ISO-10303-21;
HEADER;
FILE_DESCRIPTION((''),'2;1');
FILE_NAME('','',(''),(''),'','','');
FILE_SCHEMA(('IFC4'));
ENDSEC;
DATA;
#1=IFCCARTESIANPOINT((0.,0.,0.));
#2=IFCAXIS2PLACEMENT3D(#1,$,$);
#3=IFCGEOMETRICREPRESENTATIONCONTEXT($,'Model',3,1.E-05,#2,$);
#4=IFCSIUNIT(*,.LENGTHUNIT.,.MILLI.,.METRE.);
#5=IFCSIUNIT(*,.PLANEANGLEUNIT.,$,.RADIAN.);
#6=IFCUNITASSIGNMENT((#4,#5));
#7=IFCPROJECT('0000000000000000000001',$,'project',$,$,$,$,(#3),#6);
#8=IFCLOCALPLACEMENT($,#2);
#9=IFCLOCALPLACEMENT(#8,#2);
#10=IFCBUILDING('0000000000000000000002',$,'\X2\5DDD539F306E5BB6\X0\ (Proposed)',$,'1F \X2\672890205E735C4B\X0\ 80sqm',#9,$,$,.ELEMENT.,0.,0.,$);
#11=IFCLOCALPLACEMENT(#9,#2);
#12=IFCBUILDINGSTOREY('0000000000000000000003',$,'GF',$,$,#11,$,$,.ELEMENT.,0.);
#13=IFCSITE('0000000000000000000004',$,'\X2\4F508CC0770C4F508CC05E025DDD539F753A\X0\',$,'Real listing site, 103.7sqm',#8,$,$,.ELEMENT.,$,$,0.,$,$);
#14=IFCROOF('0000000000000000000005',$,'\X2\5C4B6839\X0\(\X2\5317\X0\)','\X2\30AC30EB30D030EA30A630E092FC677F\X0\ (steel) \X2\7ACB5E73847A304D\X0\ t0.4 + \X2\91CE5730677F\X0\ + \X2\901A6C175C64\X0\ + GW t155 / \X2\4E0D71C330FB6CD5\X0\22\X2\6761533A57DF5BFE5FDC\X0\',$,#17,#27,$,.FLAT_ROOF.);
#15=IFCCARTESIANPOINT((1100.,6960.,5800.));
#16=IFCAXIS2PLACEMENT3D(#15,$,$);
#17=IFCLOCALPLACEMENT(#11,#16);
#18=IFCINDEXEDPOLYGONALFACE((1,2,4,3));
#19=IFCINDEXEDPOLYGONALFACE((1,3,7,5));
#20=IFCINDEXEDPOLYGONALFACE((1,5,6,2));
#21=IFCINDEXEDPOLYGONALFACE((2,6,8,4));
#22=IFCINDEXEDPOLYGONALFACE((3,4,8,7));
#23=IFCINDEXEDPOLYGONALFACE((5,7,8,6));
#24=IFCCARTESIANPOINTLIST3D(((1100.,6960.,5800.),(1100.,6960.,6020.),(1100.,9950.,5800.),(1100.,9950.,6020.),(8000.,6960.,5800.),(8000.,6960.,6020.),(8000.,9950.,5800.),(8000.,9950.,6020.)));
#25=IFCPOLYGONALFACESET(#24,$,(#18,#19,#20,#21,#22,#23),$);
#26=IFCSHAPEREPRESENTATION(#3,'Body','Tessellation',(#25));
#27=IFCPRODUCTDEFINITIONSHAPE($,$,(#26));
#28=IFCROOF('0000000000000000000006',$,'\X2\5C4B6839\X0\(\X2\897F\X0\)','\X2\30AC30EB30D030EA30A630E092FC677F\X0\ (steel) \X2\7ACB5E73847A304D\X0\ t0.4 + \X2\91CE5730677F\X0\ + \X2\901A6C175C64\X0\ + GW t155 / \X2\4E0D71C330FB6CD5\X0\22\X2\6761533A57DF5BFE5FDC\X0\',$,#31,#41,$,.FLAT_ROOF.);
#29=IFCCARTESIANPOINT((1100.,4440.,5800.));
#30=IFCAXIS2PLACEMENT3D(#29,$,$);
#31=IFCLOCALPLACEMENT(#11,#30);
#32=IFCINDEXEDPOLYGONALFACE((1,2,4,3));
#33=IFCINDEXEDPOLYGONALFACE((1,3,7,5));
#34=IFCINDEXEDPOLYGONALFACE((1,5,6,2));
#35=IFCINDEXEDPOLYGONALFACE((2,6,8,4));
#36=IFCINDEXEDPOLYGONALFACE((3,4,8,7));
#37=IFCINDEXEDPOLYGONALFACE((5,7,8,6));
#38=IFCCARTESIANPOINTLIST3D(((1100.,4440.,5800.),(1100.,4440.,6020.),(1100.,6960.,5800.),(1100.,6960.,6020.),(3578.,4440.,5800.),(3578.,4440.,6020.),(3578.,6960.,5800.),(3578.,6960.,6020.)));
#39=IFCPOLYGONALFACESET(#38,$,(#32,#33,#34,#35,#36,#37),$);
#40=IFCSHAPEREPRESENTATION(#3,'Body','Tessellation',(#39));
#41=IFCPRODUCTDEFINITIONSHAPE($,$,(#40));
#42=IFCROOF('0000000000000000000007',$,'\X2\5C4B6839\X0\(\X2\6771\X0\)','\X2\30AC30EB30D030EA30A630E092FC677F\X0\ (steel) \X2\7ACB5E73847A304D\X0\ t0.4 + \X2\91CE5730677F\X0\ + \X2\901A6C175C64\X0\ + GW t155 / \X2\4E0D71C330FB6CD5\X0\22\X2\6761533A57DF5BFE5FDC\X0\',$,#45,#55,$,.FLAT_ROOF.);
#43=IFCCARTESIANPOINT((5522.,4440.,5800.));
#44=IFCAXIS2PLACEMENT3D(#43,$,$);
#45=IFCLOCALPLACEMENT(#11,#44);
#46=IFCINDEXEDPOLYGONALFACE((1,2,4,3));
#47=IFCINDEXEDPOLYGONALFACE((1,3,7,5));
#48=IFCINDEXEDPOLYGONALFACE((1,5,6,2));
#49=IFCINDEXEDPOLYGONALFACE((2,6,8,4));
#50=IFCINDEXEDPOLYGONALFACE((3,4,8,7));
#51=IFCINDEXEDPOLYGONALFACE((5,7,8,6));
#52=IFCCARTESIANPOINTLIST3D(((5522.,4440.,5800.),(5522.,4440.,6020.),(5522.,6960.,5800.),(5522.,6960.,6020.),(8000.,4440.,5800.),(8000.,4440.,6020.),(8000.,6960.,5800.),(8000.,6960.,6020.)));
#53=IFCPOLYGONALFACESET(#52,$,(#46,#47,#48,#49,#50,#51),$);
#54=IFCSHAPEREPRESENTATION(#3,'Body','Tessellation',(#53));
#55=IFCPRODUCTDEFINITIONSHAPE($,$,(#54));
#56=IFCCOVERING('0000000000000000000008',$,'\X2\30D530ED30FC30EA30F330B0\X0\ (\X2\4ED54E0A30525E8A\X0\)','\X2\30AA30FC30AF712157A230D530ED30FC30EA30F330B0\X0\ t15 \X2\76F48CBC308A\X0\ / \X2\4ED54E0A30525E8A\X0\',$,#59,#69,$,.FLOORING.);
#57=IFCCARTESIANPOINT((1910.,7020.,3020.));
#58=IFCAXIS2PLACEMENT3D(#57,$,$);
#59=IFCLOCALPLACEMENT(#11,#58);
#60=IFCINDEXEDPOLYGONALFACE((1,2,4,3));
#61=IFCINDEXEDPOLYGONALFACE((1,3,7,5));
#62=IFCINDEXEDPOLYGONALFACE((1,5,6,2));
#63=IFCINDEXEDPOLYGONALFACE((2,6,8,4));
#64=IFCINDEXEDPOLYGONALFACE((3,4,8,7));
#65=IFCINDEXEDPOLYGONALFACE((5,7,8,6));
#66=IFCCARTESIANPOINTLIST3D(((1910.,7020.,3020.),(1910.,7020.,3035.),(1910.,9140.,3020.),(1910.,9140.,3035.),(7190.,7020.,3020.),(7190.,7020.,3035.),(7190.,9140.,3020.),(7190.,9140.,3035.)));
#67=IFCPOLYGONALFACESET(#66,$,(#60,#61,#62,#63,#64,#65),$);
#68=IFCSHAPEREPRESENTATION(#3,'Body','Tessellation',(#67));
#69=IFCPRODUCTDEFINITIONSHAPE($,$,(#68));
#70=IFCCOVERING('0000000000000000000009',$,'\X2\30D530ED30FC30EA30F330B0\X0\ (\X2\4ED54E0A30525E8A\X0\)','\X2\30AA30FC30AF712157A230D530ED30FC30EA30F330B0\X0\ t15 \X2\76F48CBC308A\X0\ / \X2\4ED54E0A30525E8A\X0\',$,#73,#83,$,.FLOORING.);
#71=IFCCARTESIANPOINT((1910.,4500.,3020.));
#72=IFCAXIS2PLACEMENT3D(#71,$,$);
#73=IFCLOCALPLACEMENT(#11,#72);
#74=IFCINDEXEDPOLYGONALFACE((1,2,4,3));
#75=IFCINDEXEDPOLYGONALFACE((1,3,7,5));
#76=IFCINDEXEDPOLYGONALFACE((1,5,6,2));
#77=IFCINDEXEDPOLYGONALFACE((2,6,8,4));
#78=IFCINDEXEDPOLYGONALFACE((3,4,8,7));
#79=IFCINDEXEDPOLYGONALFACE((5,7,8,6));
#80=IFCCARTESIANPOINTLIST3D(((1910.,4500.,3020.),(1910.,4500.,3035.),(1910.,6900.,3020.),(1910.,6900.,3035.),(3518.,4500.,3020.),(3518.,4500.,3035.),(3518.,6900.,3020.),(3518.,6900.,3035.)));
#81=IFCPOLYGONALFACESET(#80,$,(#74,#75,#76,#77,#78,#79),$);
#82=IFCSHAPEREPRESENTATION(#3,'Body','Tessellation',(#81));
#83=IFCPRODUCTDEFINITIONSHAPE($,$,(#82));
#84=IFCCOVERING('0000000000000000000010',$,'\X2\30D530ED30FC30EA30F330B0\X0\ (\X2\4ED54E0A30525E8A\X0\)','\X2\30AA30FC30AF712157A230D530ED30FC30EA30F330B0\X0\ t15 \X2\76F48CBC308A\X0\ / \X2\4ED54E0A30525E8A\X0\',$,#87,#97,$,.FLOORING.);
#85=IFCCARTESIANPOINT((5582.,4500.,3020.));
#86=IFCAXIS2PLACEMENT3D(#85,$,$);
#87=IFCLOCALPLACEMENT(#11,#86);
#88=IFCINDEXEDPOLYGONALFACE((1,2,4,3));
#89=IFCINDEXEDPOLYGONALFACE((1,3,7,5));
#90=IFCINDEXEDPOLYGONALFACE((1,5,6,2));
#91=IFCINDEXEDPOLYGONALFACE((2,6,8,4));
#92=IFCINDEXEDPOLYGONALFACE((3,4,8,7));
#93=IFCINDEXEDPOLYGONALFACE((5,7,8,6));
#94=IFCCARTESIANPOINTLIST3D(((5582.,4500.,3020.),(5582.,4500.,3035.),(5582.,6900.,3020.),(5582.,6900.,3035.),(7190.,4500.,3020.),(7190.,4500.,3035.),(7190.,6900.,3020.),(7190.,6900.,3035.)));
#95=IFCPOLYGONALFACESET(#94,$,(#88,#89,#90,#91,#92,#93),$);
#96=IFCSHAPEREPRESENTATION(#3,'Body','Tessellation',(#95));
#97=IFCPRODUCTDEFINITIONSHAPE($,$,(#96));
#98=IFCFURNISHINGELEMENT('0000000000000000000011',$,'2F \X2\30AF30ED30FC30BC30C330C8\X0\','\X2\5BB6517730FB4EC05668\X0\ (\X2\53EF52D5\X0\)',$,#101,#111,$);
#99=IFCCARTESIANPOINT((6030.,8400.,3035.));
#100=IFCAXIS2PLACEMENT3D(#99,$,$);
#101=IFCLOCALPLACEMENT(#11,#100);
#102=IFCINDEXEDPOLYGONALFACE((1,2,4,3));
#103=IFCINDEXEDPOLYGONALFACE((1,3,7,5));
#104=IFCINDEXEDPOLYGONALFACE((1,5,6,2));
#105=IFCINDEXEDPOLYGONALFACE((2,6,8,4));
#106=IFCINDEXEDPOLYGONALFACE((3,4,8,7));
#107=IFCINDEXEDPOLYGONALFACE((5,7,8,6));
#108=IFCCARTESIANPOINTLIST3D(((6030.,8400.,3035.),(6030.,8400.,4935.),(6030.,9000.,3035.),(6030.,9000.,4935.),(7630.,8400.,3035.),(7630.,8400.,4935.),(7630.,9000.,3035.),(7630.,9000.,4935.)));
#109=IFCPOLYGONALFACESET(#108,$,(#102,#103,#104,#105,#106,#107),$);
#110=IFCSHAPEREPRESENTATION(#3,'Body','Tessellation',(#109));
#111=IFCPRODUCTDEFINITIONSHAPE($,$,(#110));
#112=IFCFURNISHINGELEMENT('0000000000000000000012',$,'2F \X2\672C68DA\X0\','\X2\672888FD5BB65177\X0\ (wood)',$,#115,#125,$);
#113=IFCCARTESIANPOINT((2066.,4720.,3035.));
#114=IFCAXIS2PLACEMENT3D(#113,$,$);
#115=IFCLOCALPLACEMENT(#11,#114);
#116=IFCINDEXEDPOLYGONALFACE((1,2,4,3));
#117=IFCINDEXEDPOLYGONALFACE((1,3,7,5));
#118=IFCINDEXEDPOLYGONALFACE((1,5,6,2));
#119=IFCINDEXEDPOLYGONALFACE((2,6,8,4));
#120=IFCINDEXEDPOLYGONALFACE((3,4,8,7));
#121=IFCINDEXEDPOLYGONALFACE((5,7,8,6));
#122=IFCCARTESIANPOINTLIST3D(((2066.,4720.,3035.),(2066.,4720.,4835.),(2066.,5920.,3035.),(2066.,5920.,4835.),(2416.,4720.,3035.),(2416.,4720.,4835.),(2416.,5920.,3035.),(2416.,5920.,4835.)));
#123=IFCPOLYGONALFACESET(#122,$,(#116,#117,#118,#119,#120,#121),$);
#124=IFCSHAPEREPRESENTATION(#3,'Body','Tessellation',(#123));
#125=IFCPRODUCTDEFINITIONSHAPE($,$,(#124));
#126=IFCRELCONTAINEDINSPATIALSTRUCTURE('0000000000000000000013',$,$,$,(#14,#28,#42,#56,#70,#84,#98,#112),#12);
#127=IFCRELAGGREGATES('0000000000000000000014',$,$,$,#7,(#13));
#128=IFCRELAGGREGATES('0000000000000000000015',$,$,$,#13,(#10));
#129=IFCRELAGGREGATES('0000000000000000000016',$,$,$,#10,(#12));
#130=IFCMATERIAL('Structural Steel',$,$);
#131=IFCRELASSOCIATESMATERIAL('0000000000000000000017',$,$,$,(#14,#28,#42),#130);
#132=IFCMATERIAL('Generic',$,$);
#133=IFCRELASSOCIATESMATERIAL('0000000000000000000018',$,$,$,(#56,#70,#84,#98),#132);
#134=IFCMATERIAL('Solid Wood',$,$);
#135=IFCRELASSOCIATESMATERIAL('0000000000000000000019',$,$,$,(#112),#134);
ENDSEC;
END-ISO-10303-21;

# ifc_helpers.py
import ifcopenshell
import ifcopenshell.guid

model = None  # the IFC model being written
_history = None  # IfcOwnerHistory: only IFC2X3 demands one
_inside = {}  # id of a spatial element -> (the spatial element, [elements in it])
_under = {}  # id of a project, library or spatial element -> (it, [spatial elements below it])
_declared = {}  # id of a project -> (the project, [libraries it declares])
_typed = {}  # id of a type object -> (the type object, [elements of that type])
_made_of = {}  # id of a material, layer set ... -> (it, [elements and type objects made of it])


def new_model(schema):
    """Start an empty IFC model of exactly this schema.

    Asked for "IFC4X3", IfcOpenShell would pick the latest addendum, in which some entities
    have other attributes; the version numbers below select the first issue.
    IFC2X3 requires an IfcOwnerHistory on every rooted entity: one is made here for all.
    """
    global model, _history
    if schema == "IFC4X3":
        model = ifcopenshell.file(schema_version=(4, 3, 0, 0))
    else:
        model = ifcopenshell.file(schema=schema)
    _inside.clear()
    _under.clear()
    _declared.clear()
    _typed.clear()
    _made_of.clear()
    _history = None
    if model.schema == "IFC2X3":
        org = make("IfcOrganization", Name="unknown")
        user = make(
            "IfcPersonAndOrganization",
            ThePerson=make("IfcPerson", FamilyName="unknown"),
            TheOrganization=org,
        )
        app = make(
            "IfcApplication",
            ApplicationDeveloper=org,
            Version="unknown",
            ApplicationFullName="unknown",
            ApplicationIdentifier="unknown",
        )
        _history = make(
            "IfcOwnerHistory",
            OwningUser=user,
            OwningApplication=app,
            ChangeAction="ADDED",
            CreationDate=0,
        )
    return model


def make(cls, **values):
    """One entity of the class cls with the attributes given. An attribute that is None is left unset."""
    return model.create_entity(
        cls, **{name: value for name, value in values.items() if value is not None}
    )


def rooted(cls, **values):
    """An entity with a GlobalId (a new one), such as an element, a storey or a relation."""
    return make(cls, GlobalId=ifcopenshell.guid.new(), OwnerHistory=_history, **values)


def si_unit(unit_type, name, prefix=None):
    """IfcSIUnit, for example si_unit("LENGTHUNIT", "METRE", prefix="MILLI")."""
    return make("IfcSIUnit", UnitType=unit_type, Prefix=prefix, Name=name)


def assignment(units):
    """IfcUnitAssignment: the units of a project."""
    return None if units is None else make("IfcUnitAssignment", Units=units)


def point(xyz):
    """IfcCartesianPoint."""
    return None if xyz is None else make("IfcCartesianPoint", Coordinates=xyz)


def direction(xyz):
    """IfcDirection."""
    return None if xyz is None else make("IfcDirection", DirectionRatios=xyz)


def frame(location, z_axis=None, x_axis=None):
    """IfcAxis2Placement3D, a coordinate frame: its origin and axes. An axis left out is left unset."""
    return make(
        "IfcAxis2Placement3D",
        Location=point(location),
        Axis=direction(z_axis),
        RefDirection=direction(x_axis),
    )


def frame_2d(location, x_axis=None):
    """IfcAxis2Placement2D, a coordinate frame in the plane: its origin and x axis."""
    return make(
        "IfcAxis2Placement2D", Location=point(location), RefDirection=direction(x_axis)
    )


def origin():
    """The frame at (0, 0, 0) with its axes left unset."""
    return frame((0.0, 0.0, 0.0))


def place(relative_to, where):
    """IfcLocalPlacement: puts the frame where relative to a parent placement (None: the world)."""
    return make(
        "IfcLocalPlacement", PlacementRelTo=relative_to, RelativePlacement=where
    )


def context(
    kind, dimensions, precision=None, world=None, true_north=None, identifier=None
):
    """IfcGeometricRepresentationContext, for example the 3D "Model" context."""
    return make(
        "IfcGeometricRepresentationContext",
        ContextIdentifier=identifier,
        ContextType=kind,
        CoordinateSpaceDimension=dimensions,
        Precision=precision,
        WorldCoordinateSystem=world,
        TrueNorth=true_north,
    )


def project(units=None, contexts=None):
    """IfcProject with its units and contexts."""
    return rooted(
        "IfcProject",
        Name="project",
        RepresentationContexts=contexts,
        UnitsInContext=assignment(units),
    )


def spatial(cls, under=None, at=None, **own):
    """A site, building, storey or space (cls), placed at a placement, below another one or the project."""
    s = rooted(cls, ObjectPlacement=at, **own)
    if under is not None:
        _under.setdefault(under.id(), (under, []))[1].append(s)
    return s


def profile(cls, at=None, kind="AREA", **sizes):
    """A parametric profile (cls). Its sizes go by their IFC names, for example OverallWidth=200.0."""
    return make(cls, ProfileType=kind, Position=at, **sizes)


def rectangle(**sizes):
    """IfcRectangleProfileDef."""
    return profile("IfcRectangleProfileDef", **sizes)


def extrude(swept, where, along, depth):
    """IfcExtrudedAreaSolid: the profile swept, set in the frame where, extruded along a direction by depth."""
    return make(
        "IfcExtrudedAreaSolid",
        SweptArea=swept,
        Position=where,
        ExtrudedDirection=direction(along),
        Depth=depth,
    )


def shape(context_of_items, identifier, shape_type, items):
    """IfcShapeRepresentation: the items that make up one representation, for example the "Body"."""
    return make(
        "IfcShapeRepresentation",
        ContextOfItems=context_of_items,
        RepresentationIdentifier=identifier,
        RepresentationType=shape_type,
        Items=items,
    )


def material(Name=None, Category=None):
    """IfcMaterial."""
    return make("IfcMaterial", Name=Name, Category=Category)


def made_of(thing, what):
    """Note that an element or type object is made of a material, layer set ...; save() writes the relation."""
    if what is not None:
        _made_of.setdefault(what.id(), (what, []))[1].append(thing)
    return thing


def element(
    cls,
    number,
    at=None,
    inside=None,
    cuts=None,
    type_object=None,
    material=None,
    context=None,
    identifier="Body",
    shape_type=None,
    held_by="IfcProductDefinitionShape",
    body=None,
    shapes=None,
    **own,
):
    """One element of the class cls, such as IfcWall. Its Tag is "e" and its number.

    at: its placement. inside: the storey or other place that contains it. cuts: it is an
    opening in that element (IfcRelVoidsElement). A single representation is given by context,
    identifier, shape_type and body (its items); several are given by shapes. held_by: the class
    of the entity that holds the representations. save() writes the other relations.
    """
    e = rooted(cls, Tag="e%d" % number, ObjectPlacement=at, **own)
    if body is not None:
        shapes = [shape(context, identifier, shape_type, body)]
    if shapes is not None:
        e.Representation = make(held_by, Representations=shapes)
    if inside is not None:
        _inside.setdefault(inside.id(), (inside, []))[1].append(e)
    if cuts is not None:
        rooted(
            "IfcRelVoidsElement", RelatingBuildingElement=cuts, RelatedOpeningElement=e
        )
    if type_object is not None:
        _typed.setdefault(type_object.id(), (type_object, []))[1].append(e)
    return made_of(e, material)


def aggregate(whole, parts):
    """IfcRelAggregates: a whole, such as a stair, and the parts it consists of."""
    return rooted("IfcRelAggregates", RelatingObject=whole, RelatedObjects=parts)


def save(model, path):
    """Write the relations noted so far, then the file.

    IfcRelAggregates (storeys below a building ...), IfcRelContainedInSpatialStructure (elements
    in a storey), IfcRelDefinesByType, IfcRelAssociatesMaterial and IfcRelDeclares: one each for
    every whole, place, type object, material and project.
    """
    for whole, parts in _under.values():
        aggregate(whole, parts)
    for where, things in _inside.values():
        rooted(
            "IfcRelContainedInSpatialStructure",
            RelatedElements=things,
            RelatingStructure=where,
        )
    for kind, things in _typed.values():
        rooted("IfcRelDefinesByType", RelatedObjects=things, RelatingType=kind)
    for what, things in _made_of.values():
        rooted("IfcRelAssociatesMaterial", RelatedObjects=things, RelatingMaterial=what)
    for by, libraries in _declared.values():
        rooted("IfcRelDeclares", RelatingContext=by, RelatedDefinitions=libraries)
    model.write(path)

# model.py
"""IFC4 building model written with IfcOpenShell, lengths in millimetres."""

from ifc_helpers import new_model, si_unit, frame, frame_2d, origin, place, context, project, spatial, rectangle, extrude, material, element, save


model = new_model("IFC4")

# Units and contexts
model_context = context("Model", 3, precision=1e-05, world=origin())
ifc_project = project(units=[si_unit("LENGTHUNIT", "METRE", prefix="MILLI"), si_unit("PLANEANGLEUNIT", "RADIAN")], contexts=[model_context])

# Site, building, storey
site_placement = place(None, origin())
site = spatial("IfcSite", under=ifc_project, at=site_placement, Name="佐賀県佐賀市川原町", ObjectType="Real listing site, 103.7sqm", CompositionType="ELEMENT", RefElevation=0.0)
building_placement = place(site_placement, origin())
building = spatial("IfcBuilding", under=site, at=building_placement, Name="川原の家 (Proposed)", ObjectType="1F 木造平屋 80sqm", CompositionType="ELEMENT", ElevationOfRefHeight=0.0, ElevationOfTerrain=0.0)
storey_placement = place(building_placement, origin())
storey = spatial("IfcBuildingStorey", under=building, at=storey_placement, Name="GF", CompositionType="ELEMENT", Elevation=0.0)

# Shared definitions
ifc_material_1 = material(Name="Solid Wood")

# Shared definitions
ifc_material_2 = material(Name="Generic")

# Roofs
ifc_material_3 = material(Name="Structural Steel")
for number, where, name in (
    (1, (1100.0, 6960.0, 5800.0), "屋根(北)"),
):
    element("IfcRoof", number, at=place(storey_placement, frame(where)), inside=storey, material=ifc_material_3, Name=name, Description="ガルバリウム鋼板 (steel) 立平葺き t0.4 + 野地板 + 通気層 + GW t155 / 不燃・法22条区域対応", PredefinedType="FLAT_ROOF", context=model_context, shape_type="SweptSolid", body=[
        extrude(rectangle(XDim=6900.0, YDim=2990.0, at=frame_2d((3450.0, 1495.0))), frame((1100.0, 6960.0, 5800.0)), (0.0, 0.0, 1.0), 220.0),
    ])
roof_1_placement = place(storey_placement, frame((1100.0, 4440.0, 5800.0)))
element("IfcRoof", 2, at=roof_1_placement, inside=storey, material=ifc_material_3, Name="屋根(西)", Description="ガルバリウム鋼板 (steel) 立平葺き t0.4 + 野地板 + 通気層 + GW t155 / 不燃・法22条区域対応", PredefinedType="FLAT_ROOF", context=model_context, shape_type="SweptSolid", body=[
    extrude(rectangle(XDim=2478.0, YDim=2520.0, at=frame_2d((1239.0, 1260.0))), frame((1100.0, 4440.0, 5800.0)), (0.0, 0.0, 1.0), 220.0),
])
roof_2_placement = place(storey_placement, frame((5522.0, 4440.0, 5800.0)))
element("IfcRoof", 3, at=roof_2_placement, inside=storey, material=ifc_material_3, Name="屋根(東)", Description="ガルバリウム鋼板 (steel) 立平葺き t0.4 + 野地板 + 通気層 + GW t155 / 不燃・法22条区域対応", PredefinedType="FLAT_ROOF", context=model_context, shape_type="SweptSolid", body=[
    extrude(rectangle(XDim=2478.0, YDim=2520.0, at=frame_2d((1239.0, 1260.0))), frame((5522.0, 4440.0, 5800.0)), (0.0, 0.0, 1.0), 220.0),
])

# Coverings
covering_1_placement = place(storey_placement, frame((1910.0, 7020.0, 3020.0)))
element("IfcCovering", 4, at=covering_1_placement, inside=storey, material=ifc_material_2, Name="フローリング (仕上げ床)", Description="オーク無垢フローリング t15 直貼り / 仕上げ床", PredefinedType="FLOORING", context=model_context, shape_type="SweptSolid", body=[
    extrude(rectangle(XDim=5280.0, YDim=2120.0, at=frame_2d((2640.0, 1060.0))), frame((1910.0, 7020.0, 3020.0)), (0.0, 0.0, 1.0), 15.0),
])
covering_2_placement = place(storey_placement, frame((1910.0, 4500.0, 3020.0)))
element("IfcCovering", 5, at=covering_2_placement, inside=storey, material=ifc_material_2, Name="フローリング (仕上げ床)", Description="オーク無垢フローリング t15 直貼り / 仕上げ床", PredefinedType="FLOORING", context=model_context, shape_type="SweptSolid", body=[
    extrude(rectangle(XDim=1608.0, YDim=2400.0, at=frame_2d((804.0, 1200.0))), frame((1910.0, 4500.0, 3020.0)), (0.0, 0.0, 1.0), 15.0),
])
covering_3_placement = place(storey_placement, frame((5582.0, 4500.0, 3020.0)))
element("IfcCovering", 6, at=covering_3_placement, inside=storey, material=ifc_material_2, Name="フローリング (仕上げ床)", Description="オーク無垢フローリング t15 直貼り / 仕上げ床", PredefinedType="FLOORING", context=model_context, shape_type="SweptSolid", body=[
    extrude(rectangle(XDim=1608.0, YDim=2400.0, at=frame_2d((804.0, 1200.0))), frame((5582.0, 4500.0, 3020.0)), (0.0, 0.0, 1.0), 15.0),
])

# Furnishing elements
furnishing_1_placement = place(storey_placement, frame((6030.0, 8400.0, 3035.0)))
element("IfcFurnishingElement", 7, at=furnishing_1_placement, inside=storey, material=ifc_material_2, Name="2F クローゼット", Description="家具・什器 (可動)", context=model_context, shape_type="SweptSolid", body=[
    extrude(rectangle(XDim=1600.0, YDim=600.0, at=frame_2d((800.0, 300.0))), frame((6030.0, 8400.0, 3035.0)), (0.0, 0.0, 1.0), 1900.0),
])
furnishing_2_placement = place(storey_placement, frame((2066.0, 4720.0, 3035.0)))
element("IfcFurnishingElement", 8, at=furnishing_2_placement, inside=storey, material=ifc_material_1, Name="2F 本棚", Description="木製家具 (wood)", context=model_context, shape_type="SweptSolid", body=[
    extrude(rectangle(XDim=350.0, YDim=1200.0, at=frame_2d((175.0, 600.0))), frame((2066.0, 4720.0, 3035.0)), (0.0, 0.0, 1.0), 1800.0),
])

save(model, "model.ifc")
